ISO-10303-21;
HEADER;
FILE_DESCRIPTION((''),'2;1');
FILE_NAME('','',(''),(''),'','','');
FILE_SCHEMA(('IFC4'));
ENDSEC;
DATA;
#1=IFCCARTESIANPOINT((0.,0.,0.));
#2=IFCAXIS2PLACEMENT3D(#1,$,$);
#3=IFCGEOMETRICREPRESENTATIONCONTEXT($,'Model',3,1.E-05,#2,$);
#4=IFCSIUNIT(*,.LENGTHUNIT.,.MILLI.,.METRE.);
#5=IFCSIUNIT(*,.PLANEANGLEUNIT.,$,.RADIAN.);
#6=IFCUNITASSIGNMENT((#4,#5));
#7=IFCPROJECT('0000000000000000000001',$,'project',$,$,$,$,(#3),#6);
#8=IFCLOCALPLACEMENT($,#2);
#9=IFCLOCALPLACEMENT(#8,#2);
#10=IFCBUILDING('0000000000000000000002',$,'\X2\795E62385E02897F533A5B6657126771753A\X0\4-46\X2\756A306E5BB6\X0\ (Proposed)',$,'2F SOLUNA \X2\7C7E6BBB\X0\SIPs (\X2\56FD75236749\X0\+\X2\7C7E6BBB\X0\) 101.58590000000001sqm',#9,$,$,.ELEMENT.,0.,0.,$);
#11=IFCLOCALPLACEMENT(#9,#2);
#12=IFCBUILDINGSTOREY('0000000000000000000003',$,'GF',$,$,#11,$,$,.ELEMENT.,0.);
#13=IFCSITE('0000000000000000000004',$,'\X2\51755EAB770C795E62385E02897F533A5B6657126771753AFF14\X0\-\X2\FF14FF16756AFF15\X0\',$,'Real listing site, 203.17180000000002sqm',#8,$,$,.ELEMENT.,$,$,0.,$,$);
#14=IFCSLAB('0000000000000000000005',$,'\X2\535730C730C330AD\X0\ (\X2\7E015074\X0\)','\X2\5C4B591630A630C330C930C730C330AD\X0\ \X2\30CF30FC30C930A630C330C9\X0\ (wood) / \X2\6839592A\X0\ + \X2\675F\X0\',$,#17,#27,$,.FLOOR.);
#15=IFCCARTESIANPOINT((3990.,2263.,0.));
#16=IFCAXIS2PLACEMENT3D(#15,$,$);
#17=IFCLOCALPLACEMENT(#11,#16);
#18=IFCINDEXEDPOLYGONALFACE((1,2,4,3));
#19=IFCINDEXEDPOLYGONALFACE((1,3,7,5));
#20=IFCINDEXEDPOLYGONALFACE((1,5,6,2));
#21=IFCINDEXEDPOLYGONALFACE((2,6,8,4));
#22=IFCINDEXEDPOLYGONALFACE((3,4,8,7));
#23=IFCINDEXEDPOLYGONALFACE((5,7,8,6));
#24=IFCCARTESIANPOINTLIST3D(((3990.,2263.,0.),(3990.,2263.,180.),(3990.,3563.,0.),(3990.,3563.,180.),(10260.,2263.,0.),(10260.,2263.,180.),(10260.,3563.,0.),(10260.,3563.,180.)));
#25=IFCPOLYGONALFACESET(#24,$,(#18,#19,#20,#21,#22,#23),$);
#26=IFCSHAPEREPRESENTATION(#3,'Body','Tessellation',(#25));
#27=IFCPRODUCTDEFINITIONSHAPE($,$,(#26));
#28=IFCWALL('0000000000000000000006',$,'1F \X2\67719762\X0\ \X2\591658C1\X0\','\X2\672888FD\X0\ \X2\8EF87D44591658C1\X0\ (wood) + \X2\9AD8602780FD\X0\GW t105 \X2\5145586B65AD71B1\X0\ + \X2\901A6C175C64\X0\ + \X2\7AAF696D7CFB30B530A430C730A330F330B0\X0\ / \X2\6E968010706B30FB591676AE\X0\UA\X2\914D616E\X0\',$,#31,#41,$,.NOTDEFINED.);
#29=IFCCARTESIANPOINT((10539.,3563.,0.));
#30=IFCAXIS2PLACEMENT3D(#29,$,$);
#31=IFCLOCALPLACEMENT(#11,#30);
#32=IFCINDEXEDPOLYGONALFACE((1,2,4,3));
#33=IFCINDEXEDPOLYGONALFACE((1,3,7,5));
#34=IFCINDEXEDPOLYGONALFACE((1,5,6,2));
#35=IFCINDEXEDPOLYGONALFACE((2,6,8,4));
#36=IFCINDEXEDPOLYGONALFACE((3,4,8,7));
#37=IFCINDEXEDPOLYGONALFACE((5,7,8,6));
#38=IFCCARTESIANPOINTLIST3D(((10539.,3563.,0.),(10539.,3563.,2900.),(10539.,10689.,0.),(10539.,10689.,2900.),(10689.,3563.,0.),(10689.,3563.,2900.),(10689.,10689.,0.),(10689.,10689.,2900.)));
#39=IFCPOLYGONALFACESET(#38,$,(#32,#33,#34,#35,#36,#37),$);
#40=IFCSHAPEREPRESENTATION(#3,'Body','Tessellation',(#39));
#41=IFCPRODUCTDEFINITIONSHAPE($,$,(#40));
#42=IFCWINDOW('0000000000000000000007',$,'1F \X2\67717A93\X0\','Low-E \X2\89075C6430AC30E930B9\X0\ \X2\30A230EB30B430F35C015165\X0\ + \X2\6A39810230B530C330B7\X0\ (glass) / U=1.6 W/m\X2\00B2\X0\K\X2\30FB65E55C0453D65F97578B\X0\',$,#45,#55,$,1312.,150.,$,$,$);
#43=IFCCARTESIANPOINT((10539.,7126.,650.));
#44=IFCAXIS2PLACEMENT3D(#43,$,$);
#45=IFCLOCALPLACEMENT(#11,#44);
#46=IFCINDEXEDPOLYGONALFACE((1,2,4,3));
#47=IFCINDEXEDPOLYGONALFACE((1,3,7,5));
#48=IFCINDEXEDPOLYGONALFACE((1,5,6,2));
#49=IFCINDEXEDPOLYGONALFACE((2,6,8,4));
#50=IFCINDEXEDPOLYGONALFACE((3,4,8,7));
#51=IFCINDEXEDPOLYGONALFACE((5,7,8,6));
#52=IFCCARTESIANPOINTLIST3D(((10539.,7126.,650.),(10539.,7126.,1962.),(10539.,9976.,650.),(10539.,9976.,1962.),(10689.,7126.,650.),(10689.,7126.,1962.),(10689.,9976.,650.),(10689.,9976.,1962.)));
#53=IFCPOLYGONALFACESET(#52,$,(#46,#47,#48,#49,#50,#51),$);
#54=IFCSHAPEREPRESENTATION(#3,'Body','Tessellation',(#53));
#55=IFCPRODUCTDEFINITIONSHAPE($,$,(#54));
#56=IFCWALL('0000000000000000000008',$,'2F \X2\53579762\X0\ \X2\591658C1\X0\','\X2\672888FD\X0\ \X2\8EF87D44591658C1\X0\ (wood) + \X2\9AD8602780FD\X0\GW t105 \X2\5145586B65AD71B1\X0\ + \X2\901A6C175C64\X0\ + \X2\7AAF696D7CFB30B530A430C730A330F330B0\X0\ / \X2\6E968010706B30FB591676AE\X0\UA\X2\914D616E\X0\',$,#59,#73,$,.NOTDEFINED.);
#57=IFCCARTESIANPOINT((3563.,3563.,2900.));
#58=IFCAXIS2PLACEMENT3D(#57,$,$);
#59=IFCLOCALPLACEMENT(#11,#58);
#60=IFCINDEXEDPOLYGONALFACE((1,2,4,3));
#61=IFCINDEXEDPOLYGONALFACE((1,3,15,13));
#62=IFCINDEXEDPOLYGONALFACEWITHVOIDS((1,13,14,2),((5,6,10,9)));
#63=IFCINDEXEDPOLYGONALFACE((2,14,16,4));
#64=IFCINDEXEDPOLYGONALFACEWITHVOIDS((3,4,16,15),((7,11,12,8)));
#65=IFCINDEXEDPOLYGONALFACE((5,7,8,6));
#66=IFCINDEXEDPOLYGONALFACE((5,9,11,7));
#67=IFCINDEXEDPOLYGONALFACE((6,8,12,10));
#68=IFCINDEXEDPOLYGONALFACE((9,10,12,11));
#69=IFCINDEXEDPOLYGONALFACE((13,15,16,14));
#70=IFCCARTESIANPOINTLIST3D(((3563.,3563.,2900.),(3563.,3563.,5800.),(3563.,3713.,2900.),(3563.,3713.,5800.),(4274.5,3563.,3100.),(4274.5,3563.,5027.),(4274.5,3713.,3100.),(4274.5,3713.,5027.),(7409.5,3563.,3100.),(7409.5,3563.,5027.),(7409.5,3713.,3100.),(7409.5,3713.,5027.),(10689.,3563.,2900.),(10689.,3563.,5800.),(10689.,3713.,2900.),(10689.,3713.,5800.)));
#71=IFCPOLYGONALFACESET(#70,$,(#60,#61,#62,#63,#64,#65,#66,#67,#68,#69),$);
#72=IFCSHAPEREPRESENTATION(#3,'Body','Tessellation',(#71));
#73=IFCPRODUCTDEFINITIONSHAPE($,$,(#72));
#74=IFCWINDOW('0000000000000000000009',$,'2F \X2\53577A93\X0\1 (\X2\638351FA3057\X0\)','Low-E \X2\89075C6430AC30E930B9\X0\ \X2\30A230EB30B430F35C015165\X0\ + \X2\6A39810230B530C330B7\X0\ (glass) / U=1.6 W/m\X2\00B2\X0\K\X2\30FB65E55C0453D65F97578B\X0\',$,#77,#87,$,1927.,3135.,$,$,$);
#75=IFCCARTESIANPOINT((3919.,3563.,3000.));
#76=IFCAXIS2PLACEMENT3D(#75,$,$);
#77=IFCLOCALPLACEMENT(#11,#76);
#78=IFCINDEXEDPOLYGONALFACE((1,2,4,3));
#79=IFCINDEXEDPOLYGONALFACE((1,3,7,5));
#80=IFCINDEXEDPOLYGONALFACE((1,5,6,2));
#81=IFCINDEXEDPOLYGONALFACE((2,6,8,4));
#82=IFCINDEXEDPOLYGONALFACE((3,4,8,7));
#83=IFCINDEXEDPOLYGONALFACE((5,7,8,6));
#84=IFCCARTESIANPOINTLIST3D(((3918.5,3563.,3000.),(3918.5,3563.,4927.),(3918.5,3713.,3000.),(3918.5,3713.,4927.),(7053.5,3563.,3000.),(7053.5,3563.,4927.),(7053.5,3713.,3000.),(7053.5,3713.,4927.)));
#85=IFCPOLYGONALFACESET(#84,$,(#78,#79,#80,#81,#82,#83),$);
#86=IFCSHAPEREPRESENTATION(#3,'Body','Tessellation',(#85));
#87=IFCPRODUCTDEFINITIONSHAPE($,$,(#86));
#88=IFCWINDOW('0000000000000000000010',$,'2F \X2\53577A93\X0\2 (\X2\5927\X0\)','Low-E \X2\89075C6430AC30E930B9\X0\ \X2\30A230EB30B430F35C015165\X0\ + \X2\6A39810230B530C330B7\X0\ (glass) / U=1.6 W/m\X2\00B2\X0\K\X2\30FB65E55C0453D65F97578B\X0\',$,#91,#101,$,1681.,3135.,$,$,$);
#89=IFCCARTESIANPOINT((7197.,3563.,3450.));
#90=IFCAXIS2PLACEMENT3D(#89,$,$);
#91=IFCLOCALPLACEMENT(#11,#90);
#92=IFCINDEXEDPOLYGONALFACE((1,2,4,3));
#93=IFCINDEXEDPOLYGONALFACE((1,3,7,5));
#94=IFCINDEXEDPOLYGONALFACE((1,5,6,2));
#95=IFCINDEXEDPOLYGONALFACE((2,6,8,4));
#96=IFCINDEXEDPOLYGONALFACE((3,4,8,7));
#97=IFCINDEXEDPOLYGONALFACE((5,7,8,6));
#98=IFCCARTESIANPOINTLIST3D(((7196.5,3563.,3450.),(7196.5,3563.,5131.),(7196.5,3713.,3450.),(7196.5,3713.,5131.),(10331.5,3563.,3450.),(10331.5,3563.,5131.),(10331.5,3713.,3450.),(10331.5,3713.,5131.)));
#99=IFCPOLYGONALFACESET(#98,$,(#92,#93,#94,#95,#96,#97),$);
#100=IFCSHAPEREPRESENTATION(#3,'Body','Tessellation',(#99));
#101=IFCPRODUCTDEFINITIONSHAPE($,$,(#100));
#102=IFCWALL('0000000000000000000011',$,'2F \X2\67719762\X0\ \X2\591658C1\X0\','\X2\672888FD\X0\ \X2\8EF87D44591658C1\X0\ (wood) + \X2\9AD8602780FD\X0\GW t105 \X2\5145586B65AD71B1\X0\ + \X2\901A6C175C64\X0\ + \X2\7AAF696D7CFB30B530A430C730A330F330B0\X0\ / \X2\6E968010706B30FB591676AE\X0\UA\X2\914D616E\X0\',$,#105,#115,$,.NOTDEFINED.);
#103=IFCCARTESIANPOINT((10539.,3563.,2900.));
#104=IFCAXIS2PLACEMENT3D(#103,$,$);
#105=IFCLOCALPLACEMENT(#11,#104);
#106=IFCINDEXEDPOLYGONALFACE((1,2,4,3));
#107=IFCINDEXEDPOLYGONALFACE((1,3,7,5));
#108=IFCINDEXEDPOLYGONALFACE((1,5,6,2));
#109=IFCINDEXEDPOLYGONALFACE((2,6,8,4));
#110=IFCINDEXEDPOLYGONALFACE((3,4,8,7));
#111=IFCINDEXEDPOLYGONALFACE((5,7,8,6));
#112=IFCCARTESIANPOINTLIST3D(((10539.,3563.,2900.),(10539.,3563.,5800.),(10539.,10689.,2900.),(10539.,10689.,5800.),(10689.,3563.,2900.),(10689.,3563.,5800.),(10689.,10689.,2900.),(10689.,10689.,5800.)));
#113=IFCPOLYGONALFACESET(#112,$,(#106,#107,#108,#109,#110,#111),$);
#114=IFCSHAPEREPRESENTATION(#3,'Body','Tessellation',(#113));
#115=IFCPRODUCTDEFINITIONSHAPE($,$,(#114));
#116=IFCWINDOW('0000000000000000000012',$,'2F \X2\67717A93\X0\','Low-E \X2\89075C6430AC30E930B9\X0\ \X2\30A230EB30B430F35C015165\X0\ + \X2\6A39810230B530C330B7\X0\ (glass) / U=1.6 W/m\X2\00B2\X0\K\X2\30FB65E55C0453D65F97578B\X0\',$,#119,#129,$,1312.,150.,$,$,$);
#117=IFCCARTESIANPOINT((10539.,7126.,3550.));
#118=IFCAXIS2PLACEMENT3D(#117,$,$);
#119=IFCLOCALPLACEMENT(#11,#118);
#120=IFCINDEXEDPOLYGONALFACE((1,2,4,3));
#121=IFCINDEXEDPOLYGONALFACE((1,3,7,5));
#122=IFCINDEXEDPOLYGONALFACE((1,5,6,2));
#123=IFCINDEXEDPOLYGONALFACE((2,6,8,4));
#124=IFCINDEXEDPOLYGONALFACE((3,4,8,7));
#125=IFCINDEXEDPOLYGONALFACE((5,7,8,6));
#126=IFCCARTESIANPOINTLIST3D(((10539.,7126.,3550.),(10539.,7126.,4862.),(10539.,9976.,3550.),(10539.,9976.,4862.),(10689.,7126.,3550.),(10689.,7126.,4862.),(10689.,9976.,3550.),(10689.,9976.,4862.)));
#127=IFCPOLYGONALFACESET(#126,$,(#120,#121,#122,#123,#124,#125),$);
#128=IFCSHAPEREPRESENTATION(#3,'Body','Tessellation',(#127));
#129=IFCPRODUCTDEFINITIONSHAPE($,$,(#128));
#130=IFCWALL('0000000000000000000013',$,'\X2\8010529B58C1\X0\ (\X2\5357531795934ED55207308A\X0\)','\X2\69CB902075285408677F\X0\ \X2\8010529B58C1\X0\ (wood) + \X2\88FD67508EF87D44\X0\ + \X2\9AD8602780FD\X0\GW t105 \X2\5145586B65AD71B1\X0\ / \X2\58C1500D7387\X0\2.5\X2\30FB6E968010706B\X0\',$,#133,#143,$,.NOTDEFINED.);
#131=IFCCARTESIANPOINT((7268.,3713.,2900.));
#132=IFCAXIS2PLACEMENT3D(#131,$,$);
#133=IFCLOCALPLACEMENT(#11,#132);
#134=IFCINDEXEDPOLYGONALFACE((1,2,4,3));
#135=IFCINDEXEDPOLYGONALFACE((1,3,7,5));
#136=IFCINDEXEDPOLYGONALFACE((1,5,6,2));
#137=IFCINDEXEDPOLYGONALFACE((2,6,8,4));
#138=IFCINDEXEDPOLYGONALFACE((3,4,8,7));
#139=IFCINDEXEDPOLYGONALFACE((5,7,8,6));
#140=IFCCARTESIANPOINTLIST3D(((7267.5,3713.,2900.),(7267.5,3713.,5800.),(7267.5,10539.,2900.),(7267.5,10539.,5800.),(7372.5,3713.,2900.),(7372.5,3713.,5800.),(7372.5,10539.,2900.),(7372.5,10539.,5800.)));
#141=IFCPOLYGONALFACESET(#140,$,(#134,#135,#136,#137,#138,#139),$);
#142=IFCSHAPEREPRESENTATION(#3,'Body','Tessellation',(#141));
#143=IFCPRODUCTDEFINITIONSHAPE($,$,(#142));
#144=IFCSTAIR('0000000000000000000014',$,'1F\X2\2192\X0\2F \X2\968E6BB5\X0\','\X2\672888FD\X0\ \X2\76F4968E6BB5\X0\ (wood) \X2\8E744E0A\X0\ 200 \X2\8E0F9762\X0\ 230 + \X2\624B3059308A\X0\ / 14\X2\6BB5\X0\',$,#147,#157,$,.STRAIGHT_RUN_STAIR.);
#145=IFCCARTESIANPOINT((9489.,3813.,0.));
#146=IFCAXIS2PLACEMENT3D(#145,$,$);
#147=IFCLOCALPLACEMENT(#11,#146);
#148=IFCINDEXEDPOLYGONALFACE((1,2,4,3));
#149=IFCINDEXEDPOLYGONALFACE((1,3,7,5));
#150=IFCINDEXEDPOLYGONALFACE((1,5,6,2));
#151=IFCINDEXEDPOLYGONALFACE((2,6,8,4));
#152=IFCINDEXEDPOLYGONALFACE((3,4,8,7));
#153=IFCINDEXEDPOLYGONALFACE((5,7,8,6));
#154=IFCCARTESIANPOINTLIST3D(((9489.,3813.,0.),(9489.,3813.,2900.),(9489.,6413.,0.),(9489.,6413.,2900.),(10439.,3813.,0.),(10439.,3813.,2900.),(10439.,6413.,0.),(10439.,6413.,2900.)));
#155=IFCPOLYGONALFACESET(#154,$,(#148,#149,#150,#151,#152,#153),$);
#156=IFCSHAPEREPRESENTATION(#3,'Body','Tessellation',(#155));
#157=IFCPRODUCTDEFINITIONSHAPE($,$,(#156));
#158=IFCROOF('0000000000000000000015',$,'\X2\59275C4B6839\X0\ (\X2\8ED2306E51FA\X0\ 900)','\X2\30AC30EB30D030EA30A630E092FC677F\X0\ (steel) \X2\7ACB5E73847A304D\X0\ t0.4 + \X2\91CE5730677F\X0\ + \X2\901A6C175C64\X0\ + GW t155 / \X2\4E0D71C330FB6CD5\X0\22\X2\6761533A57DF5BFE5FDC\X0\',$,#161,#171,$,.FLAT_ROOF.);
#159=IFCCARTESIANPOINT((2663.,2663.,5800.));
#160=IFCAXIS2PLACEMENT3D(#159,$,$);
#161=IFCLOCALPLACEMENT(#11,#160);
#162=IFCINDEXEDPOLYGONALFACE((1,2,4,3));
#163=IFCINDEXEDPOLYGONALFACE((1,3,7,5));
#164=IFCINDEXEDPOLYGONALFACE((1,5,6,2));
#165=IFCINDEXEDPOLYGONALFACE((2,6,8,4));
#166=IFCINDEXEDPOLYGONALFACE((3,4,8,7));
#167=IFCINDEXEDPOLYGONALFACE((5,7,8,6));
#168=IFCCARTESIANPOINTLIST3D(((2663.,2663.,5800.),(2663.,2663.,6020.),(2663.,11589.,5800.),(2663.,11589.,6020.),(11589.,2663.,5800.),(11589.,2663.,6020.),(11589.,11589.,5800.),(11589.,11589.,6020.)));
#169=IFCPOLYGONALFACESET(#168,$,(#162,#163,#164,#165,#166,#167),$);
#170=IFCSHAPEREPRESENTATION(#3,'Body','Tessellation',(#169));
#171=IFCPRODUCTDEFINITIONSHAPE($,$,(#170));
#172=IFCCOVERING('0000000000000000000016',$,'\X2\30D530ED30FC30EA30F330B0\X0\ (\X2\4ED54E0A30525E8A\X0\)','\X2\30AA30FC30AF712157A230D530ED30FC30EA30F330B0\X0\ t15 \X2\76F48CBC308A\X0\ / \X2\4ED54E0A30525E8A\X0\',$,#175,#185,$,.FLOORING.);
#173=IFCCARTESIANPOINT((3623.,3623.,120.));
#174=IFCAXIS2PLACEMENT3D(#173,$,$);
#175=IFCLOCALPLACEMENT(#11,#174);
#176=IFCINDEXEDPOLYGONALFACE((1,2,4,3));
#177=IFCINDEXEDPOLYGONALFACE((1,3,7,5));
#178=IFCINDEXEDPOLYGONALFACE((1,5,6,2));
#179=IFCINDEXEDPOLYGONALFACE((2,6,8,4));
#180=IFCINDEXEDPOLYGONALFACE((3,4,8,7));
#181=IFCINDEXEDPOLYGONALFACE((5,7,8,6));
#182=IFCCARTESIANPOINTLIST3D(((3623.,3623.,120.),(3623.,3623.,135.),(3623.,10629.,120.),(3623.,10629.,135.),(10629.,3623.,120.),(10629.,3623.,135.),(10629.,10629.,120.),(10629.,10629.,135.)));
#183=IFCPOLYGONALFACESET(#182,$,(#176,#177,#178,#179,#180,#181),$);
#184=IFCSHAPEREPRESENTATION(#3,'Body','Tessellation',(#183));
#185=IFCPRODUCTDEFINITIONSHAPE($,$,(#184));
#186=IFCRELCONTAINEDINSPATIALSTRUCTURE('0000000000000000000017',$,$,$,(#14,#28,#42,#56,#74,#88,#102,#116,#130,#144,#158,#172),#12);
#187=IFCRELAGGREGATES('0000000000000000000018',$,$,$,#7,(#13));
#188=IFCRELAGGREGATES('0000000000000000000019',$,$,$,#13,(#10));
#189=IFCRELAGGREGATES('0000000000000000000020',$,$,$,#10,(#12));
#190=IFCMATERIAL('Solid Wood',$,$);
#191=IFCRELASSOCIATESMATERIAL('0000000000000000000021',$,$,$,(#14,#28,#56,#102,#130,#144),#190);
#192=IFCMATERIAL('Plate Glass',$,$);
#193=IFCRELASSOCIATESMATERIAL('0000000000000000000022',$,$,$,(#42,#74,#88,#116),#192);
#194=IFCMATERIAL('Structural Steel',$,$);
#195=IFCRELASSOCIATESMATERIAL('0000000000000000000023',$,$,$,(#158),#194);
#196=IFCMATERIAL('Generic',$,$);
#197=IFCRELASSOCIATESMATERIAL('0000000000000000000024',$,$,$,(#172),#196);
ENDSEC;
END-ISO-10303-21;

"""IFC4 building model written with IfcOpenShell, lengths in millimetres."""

from ifc_helpers import new_model, si_unit, frame, frame_2d, origin, place, context, project, spatial, rectangle, extrude, material, element, fill, save


model = new_model("IFC4")

# Units and contexts
model_context = context("Model", 3, precision=1e-05, world=origin())
ifc_project = project(units=[si_unit("LENGTHUNIT", "METRE", prefix="MILLI"), si_unit("PLANEANGLEUNIT", "RADIAN")], contexts=[model_context])

# Site, building, storey
site_placement = place(None, origin())
site = spatial("IfcSite", under=ifc_project, at=site_placement, Name="兵庫県神戸市西区学園東町４-４６番５", ObjectType="Real listing site, 203.17180000000002sqm", CompositionType="ELEMENT", RefElevation=0.0)
building_placement = place(site_placement, origin())
building = spatial("IfcBuilding", under=site, at=building_placement, Name="神戸市西区学園東町4-46番の家 (Proposed)", ObjectType="2F SOLUNA 籾殻SIPs (国産杉+籾殻) 101.58590000000001sqm", CompositionType="ELEMENT", ElevationOfRefHeight=0.0, ElevationOfTerrain=0.0)
storey_placement = place(building_placement, origin())
storey = spatial("IfcBuildingStorey", under=building, at=storey_placement, Name="GF", CompositionType="ELEMENT", Elevation=0.0)

# Slab
ifc_material_1 = material(Name="Solid Wood")
slab_1_placement = place(storey_placement, frame((3990.0, 2263.0, 0.0)))
element("IfcSlab", 1, at=slab_1_placement, inside=storey, material=ifc_material_1, Name="南デッキ (縁側)", Description="屋外ウッドデッキ ハードウッド (wood) / 根太 + 束", PredefinedType="FLOOR", context=model_context, shape_type="SweptSolid", body=[
    extrude(rectangle(XDim=6270.0, YDim=1300.0, at=frame_2d((3135.0, 650.0))), frame((3990.0, 2263.0, 0.0)), (0.0, 0.0, 1.0), 180.0),
])

# Shared definitions
ifc_material_2 = material(Name="Plate Glass")

# Wall, opening, window
wall_1_placement = place(storey_placement, frame((10539.0, 3563.0, 0.0)))
wall_1 = element("IfcWall", 2, at=wall_1_placement, inside=storey, material=ifc_material_1, Name="1F 東面 外壁", Description="木製 軸組外壁 (wood) + 高性能GW t105 充填断熱 + 通気層 + 窯業系サイディング / 準耐火・外皮UA配慮", PredefinedType="NOTDEFINED", context=model_context, shape_type="SweptSolid", body=[
    extrude(rectangle(XDim=150.0, YDim=7126.0, at=frame_2d((75.0, 3563.0))), frame((10539.0, 3563.0, 0.0)), (0.0, 0.0, 1.0), 2900.0),
])
opening_1_placement = place(storey_placement, frame((10539.0, 7126.0, 650.0)))
opening_1 = element("IfcOpeningElement", 3, at=opening_1_placement, cuts=wall_1, PredefinedType="NOTDEFINED", context=model_context, shape_type="SweptSolid", body=[
    extrude(rectangle(XDim=150.0, YDim=2850.0, at=frame_2d((75.0, 1425.0))), frame((10539.0, 7126.0, 650.0)), (0.0, 0.0, 1.0), 1312.0),
])
window_1_placement = place(storey_placement, frame((10539.0, 7126.0, 650.0)))
window_1 = element("IfcWindow", 4, at=window_1_placement, inside=storey, material=ifc_material_2, Name="1F 東窓", Description="Low-E 複層ガラス アルゴン封入 + 樹脂サッシ (glass) / U=1.6 W/m²K・日射取得型", OverallHeight=1312.0, OverallWidth=150.0, context=model_context, shape_type="SweptSolid", body=[
    extrude(rectangle(XDim=150.0, YDim=2850.0, at=frame_2d((75.0, 1425.0))), frame((10539.0, 7126.0, 650.0)), (0.0, 0.0, 1.0), 1312.0),
])
fill(opening_1, window_1)

# Wall, openings, windows
wall_2_placement = place(storey_placement, frame((3563.0, 3563.0, 2900.0)))
wall_2 = element("IfcWall", 5, at=wall_2_placement, inside=storey, material=ifc_material_1, Name="2F 南面 外壁", Description="木製 軸組外壁 (wood) + 高性能GW t105 充填断熱 + 通気層 + 窯業系サイディング / 準耐火・外皮UA配慮", PredefinedType="NOTDEFINED", context=model_context, shape_type="SweptSolid", body=[
    extrude(rectangle(XDim=7126.0, YDim=150.0, at=frame_2d((3563.0, 75.0))), frame((3563.0, 3563.0, 2900.0)), (0.0, 0.0, 1.0), 2900.0),
])
opening_2_placement = place(storey_placement, frame((3919.0, 3563.0, 3000.0)))
opening_2 = element("IfcOpeningElement", 6, at=opening_2_placement, cuts=wall_2, PredefinedType="NOTDEFINED", context=model_context, shape_type="SweptSolid", body=[
    extrude(rectangle(XDim=3135.0, YDim=150.0, at=frame_2d((1567.0, 75.0))), frame((3919.0, 3563.0, 3000.0)), (0.0, 0.0, 1.0), 1927.0),
])
opening_3_placement = place(storey_placement, frame((7197.0, 3563.0, 3450.0)))
opening_3 = element("IfcOpeningElement", 7, at=opening_3_placement, cuts=wall_2, PredefinedType="NOTDEFINED", context=model_context, shape_type="SweptSolid", body=[
    extrude(rectangle(XDim=3135.0, YDim=150.0, at=frame_2d((1567.0, 75.0))), frame((7197.0, 3563.0, 3450.0)), (0.0, 0.0, 1.0), 1681.0),
])
window_2_placement = place(storey_placement, frame((3919.0, 3563.0, 3000.0)))
window_2 = element("IfcWindow", 8, at=window_2_placement, inside=storey, material=ifc_material_2, Name="2F 南窓1 (掃出し)", Description="Low-E 複層ガラス アルゴン封入 + 樹脂サッシ (glass) / U=1.6 W/m²K・日射取得型", OverallHeight=1927.0, OverallWidth=3135.0, context=model_context, shape_type="SweptSolid", body=[
    extrude(rectangle(XDim=3135.0, YDim=150.0, at=frame_2d((1567.0, 75.0))), frame((3919.0, 3563.0, 3000.0)), (0.0, 0.0, 1.0), 1927.0),
])
fill(opening_2, window_2)
window_3_placement = place(storey_placement, frame((7197.0, 3563.0, 3450.0)))
window_3 = element("IfcWindow", 9, at=window_3_placement, inside=storey, material=ifc_material_2, Name="2F 南窓2 (大)", Description="Low-E 複層ガラス アルゴン封入 + 樹脂サッシ (glass) / U=1.6 W/m²K・日射取得型", OverallHeight=1681.0, OverallWidth=3135.0, context=model_context, shape_type="SweptSolid", body=[
    extrude(rectangle(XDim=3135.0, YDim=150.0, at=frame_2d((1567.0, 75.0))), frame((7197.0, 3563.0, 3450.0)), (0.0, 0.0, 1.0), 1681.0),
])
fill(opening_3, window_3)

# Wall, opening, window
wall_3_placement = place(storey_placement, frame((10539.0, 3563.0, 2900.0)))
wall_3 = element("IfcWall", 10, at=wall_3_placement, inside=storey, material=ifc_material_1, Name="2F 東面 外壁", Description="木製 軸組外壁 (wood) + 高性能GW t105 充填断熱 + 通気層 + 窯業系サイディング / 準耐火・外皮UA配慮", PredefinedType="NOTDEFINED", context=model_context, shape_type="SweptSolid", body=[
    extrude(rectangle(XDim=150.0, YDim=7126.0, at=frame_2d((75.0, 3563.0))), frame((10539.0, 3563.0, 2900.0)), (0.0, 0.0, 1.0), 2900.0),
])
opening_4_placement = place(storey_placement, frame((10539.0, 7126.0, 3550.0)))
opening_4 = element("IfcOpeningElement", 11, at=opening_4_placement, cuts=wall_3, PredefinedType="NOTDEFINED", context=model_context, shape_type="SweptSolid", body=[
    extrude(rectangle(XDim=150.0, YDim=2850.0, at=frame_2d((75.0, 1425.0))), frame((10539.0, 7126.0, 3550.0)), (0.0, 0.0, 1.0), 1312.0),
])
window_4_placement = place(storey_placement, frame((10539.0, 7126.0, 3550.0)))
window_4 = element("IfcWindow", 12, at=window_4_placement, inside=storey, material=ifc_material_2, Name="2F 東窓", Description="Low-E 複層ガラス アルゴン封入 + 樹脂サッシ (glass) / U=1.6 W/m²K・日射取得型", OverallHeight=1312.0, OverallWidth=150.0, context=model_context, shape_type="SweptSolid", body=[
    extrude(rectangle(XDim=150.0, YDim=2850.0, at=frame_2d((75.0, 1425.0))), frame((10539.0, 7126.0, 3550.0)), (0.0, 0.0, 1.0), 1312.0),
])
fill(opening_4, window_4)

# Wall
wall_4_placement = place(storey_placement, frame((7268.0, 3713.0, 2900.0)))
element("IfcWall", 13, at=wall_4_placement, inside=storey, material=ifc_material_1, Name="耐力壁 (南北間仕切り)", Description="構造用合板 耐力壁 (wood) + 製材軸組 + 高性能GW t105 充填断熱 / 壁倍率2.5・準耐火", PredefinedType="NOTDEFINED", context=model_context, shape_type="SweptSolid", body=[
    extrude(rectangle(XDim=105.0, YDim=6826.0, at=frame_2d((52.0, 3413.0))), frame((7268.0, 3713.0, 2900.0)), (0.0, 0.0, 1.0), 2900.0),
])

# Stair
stair_placement = place(storey_placement, frame((9489.0, 3813.0, 0.0)))
element("IfcStair", 14, at=stair_placement, inside=storey, material=ifc_material_1, Name="1F→2F 階段", Description="木製 直階段 (wood) 蹴上 200 踏面 230 + 手すり / 14段", PredefinedType="STRAIGHT_RUN_STAIR", context=model_context, shape_type="SweptSolid", body=[
    extrude(rectangle(XDim=950.0, YDim=2600.0, at=frame_2d((475.0, 1300.0))), frame((9489.0, 3813.0, 0.0)), (0.0, 0.0, 1.0), 2900.0),
])

# Roof
ifc_material_3 = material(Name="Structural Steel")
roof_placement = place(storey_placement, frame((2663.0, 2663.0, 5800.0)))
element("IfcRoof", 15, at=roof_placement, inside=storey, material=ifc_material_3, Name="大屋根 (軒の出 900)", Description="ガルバリウム鋼板 (steel) 立平葺き t0.4 + 野地板 + 通気層 + GW t155 / 不燃・法22条区域対応", PredefinedType="FLAT_ROOF", context=model_context, shape_type="SweptSolid", body=[
    extrude(rectangle(XDim=8926.0, YDim=8926.0, at=frame_2d((4463.0, 4463.0))), frame((2663.0, 2663.0, 5800.0)), (0.0, 0.0, 1.0), 220.0),
])

# Covering
ifc_material_4 = material(Name="Generic")
covering_1_placement = place(storey_placement, frame((3623.0, 3623.0, 120.0)))
element("IfcCovering", 16, at=covering_1_placement, inside=storey, material=ifc_material_4, Name="フローリング (仕上げ床)", Description="オーク無垢フローリング t15 直貼り / 仕上げ床", PredefinedType="FLOORING", context=model_context, shape_type="SweptSolid", body=[
    extrude(rectangle(XDim=7006.0, YDim=7006.0, at=frame_2d((3503.0, 3503.0))), frame((3623.0, 3623.0, 120.0)), (0.0, 0.0, 1.0), 15.0),
])

save(model, "model.ifc")
